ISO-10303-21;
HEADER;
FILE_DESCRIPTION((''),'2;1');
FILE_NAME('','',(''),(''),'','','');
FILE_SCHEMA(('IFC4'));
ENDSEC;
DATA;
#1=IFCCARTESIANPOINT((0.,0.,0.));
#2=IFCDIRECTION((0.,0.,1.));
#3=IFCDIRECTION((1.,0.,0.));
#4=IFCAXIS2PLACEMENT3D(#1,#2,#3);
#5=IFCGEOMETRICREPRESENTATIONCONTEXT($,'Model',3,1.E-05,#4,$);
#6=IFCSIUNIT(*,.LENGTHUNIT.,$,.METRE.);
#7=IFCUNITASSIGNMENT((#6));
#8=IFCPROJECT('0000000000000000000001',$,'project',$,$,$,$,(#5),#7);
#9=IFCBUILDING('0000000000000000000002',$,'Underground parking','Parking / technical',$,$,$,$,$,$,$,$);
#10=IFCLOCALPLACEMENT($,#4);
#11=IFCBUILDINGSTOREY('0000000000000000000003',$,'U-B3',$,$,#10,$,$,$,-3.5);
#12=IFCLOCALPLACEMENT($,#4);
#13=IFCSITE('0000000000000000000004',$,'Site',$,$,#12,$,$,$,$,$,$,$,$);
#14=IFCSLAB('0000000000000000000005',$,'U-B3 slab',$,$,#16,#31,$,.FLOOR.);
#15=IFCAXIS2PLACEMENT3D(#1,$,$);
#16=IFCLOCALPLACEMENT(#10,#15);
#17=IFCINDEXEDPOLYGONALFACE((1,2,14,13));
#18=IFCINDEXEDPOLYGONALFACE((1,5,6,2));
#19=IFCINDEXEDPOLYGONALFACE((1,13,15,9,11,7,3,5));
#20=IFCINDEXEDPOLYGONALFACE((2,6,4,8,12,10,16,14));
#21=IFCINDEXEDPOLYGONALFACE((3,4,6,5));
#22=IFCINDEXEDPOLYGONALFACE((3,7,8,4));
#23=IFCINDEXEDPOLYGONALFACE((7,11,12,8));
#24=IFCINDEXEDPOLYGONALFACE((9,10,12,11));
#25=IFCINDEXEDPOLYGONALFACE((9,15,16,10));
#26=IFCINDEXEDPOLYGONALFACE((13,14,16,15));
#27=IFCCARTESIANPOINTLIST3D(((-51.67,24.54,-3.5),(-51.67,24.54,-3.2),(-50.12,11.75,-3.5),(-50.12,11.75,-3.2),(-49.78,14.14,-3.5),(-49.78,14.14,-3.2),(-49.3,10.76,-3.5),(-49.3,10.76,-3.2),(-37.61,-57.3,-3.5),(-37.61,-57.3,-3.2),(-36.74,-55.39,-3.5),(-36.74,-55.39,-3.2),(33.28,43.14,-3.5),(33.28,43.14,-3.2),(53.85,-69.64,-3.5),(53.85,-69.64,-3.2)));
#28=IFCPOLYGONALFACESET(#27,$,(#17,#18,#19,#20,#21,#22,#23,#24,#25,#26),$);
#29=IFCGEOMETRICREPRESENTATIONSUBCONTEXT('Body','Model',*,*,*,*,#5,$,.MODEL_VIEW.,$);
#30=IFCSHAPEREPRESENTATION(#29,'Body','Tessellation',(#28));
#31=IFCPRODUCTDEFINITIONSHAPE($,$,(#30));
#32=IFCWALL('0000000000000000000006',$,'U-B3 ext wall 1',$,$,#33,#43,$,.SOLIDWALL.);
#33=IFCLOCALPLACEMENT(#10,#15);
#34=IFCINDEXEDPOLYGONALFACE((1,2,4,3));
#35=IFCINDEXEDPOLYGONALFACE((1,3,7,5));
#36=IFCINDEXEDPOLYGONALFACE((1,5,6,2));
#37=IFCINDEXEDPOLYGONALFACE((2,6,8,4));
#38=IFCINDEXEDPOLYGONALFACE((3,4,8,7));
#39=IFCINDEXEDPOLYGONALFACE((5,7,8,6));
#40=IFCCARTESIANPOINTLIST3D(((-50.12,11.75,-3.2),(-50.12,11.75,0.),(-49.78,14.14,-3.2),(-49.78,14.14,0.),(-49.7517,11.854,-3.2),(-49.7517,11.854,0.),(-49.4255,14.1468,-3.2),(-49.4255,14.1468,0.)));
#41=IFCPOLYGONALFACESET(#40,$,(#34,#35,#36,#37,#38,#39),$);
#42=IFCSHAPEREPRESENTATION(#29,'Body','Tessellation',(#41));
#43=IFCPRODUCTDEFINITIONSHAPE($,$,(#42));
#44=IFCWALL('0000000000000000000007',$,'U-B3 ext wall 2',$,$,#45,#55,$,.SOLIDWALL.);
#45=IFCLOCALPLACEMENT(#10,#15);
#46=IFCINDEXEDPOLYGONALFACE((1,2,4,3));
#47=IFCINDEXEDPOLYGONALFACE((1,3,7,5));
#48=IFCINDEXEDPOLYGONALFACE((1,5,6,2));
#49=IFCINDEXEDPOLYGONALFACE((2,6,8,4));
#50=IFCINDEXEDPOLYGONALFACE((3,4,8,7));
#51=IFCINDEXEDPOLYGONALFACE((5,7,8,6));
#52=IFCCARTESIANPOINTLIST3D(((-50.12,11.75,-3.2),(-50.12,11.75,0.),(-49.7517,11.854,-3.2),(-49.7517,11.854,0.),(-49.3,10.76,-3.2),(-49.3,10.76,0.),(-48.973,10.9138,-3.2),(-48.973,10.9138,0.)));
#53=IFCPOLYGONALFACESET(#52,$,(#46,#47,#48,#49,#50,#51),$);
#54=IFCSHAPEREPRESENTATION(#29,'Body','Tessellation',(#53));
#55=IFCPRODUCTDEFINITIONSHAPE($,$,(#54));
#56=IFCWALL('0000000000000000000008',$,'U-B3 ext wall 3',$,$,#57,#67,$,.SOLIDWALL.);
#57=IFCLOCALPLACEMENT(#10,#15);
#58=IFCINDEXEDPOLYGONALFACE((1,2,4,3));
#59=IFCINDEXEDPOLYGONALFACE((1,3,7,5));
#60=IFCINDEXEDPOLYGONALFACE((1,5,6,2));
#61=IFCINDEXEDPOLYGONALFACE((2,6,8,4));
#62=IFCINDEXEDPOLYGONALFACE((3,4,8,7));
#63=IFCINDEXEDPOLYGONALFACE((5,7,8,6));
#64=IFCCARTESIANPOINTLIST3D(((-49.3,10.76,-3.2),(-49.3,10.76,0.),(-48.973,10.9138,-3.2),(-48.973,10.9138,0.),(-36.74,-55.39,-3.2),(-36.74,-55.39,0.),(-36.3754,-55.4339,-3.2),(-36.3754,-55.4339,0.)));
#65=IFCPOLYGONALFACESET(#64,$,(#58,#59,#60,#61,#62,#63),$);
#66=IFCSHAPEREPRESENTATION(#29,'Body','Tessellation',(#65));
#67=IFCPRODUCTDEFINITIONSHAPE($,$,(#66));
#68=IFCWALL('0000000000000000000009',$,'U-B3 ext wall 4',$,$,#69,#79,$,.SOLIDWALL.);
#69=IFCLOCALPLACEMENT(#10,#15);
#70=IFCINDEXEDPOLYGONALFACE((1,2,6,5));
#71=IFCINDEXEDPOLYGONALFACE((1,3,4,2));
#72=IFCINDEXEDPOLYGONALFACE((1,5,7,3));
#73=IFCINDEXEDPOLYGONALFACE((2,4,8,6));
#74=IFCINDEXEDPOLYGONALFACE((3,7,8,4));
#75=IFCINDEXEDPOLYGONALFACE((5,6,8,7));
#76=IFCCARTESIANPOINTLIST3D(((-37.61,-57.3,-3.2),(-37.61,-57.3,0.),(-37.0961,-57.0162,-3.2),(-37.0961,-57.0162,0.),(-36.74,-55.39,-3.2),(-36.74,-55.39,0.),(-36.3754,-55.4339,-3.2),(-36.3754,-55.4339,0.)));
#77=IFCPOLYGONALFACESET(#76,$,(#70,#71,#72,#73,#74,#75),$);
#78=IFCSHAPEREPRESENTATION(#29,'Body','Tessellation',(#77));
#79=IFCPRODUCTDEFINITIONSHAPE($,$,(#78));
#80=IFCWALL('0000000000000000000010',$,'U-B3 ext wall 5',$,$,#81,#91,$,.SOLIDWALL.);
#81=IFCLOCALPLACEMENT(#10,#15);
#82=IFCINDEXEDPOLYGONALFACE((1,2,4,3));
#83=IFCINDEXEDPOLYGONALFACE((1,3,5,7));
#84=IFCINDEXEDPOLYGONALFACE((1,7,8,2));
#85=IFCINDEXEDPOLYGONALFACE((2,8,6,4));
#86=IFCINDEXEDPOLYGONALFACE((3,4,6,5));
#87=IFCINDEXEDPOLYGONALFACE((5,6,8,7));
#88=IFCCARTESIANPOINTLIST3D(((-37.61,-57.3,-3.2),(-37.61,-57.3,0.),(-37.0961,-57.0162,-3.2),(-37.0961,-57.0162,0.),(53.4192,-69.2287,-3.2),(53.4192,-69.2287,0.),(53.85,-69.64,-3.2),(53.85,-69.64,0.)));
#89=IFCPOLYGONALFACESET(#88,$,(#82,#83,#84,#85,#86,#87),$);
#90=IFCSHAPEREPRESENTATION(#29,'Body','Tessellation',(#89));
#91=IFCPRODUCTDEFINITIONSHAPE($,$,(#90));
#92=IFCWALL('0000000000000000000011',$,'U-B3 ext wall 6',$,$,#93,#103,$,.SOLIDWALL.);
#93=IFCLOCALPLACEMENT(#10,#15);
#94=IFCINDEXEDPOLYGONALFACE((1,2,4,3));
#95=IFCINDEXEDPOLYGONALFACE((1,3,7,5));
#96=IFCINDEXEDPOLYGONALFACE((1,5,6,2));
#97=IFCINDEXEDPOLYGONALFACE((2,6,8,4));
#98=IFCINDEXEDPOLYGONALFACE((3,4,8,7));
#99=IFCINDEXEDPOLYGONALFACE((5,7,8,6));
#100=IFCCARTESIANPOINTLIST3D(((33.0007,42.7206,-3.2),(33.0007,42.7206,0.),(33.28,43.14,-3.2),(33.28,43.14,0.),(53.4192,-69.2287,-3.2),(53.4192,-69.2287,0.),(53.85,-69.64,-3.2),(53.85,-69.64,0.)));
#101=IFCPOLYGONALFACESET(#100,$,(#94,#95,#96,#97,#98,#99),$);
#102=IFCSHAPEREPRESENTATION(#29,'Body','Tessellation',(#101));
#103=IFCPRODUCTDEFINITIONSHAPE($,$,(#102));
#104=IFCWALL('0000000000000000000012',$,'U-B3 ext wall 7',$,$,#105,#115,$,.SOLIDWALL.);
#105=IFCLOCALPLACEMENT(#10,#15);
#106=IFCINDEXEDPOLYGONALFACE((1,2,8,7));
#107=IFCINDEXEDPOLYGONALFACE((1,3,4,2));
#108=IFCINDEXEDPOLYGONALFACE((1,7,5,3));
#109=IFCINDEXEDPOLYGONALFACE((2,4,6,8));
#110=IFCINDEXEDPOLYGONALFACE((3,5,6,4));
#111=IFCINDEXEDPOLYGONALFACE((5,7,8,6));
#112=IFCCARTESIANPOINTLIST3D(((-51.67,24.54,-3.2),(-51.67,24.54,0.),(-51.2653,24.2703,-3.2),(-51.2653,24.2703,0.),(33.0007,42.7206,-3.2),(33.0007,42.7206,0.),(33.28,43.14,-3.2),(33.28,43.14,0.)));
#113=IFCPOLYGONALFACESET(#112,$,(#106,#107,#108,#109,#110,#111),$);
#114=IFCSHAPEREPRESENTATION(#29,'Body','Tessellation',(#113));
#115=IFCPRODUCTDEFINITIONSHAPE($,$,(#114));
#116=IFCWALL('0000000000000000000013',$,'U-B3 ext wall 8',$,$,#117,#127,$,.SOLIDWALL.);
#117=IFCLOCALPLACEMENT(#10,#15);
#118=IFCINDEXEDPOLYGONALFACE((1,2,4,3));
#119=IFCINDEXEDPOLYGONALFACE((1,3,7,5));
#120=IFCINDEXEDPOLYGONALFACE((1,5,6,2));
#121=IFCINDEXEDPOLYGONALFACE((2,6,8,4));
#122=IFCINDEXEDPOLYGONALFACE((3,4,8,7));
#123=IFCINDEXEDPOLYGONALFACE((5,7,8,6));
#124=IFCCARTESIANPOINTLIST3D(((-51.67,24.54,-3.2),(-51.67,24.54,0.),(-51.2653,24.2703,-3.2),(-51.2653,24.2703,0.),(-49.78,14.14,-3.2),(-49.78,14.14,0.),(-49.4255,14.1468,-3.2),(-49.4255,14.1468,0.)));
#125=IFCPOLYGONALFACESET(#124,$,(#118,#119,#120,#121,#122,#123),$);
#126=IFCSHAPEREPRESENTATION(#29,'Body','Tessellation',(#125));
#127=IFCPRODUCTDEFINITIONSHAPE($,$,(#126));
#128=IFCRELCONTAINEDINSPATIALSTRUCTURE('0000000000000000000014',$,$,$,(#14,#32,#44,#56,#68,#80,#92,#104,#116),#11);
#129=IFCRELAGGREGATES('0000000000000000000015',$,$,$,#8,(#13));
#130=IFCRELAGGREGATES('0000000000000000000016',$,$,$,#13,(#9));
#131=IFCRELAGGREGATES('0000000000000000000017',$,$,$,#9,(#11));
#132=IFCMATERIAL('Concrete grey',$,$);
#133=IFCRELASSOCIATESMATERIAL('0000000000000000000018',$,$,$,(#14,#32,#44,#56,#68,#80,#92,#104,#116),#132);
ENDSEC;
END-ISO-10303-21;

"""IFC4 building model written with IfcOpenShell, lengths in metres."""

from ifc_helpers import new_model, si_unit, frame, origin_with_axes, place, context, subcontext, project, spatial, polyline, outline, extrude, material, element, save


model = new_model("IFC4")

# Units and contexts
model_context = context("Model", 3, precision=1e-05, world=origin_with_axes())
body_context = subcontext(model_context, "Body", "Model", "MODEL_VIEW")
ifc_project = project(units=[si_unit("LENGTHUNIT", "METRE")], contexts=[model_context])

# Site, building, storey
site_placement = place(None, origin_with_axes())
site = spatial("IfcSite", under=ifc_project, at=site_placement, Name="Site")
building = spatial("IfcBuilding", under=site, Name="Underground parking", Description="Parking / technical")
storey_placement = place(None, origin_with_axes())
storey = spatial("IfcBuildingStorey", under=building, at=storey_placement, Name="U-B3", Elevation=-3.5)

# Slab
ifc_material = material(Name="Concrete grey")
slab_placement = place(storey_placement, origin_with_axes())
element("IfcSlab", 1, at=slab_placement, inside=storey, material=ifc_material, Name="U-B3 slab", PredefinedType="FLOOR", context=body_context, shape_type="SweptSolid", body=[
    extrude(outline(polyline([(-49.78, 14.14), (-50.12, 11.75), (-49.3, 10.76), (-36.74, -55.39), (-37.61, -57.3), (53.85, -69.64), (33.28, 43.14), (-51.67, 24.54), (-49.78, 14.14)])), frame((0.0, 0.0, -3.5), z_axis=(0.0, 0.0, 1.0), x_axis=(1.0, 0.0, 0.0)), (0.0, 0.0, 1.0), 0.3),
])

# Walls
wall_1_placement = place(storey_placement, origin_with_axes())
element("IfcWall", 2, at=wall_1_placement, inside=storey, material=ifc_material, Name="U-B3 ext wall 1", PredefinedType="SOLIDWALL", context=body_context, shape_type="SweptSolid", body=[
    extrude(outline(polyline([(-49.78, 14.14), (-50.12, 11.75), (-49.7517, 11.854), (-49.4255, 14.1468), (-49.78, 14.14)])), frame((0.0, 0.0, -3.2), z_axis=(0.0, 0.0, 1.0), x_axis=(1.0, 0.0, 0.0)), (0.0, 0.0, 1.0), 3.2),
])
wall_2_placement = place(storey_placement, origin_with_axes())
element("IfcWall", 3, at=wall_2_placement, inside=storey, material=ifc_material, Name="U-B3 ext wall 2", PredefinedType="SOLIDWALL", context=body_context, shape_type="SweptSolid", body=[
    extrude(outline(polyline([(-50.12, 11.75), (-49.3, 10.76), (-48.973, 10.9138), (-49.7517, 11.854), (-50.12, 11.75)])), frame((0.0, 0.0, -3.2), z_axis=(0.0, 0.0, 1.0), x_axis=(1.0, 0.0, 0.0)), (0.0, 0.0, 1.0), 3.2),
])
wall_3_placement = place(storey_placement, origin_with_axes())
element("IfcWall", 4, at=wall_3_placement, inside=storey, material=ifc_material, Name="U-B3 ext wall 3", PredefinedType="SOLIDWALL", context=body_context, shape_type="SweptSolid", body=[
    extrude(outline(polyline([(-49.3, 10.76), (-36.74, -55.39), (-36.3754, -55.4339), (-48.973, 10.9138), (-49.3, 10.76)])), frame((0.0, 0.0, -3.2), z_axis=(0.0, 0.0, 1.0), x_axis=(1.0, 0.0, 0.0)), (0.0, 0.0, 1.0), 3.2),
])
wall_4_placement = place(storey_placement, origin_with_axes())
element("IfcWall", 5, at=wall_4_placement, inside=storey, material=ifc_material, Name="U-B3 ext wall 4", PredefinedType="SOLIDWALL", context=body_context, shape_type="SweptSolid", body=[
    extrude(outline(polyline([(-36.74, -55.39), (-37.61, -57.3), (-37.0961, -57.0162), (-36.3754, -55.4339), (-36.74, -55.39)])), frame((0.0, 0.0, -3.2), z_axis=(0.0, 0.0, 1.0), x_axis=(1.0, 0.0, 0.0)), (0.0, 0.0, 1.0), 3.2),
])
wall_5_placement = place(storey_placement, origin_with_axes())
element("IfcWall", 6, at=wall_5_placement, inside=storey, material=ifc_material, Name="U-B3 ext wall 5", PredefinedType="SOLIDWALL", context=body_context, shape_type="SweptSolid", body=[
    extrude(outline(polyline([(-37.61, -57.3), (53.85, -69.64), (53.4192, -69.2287), (-37.0961, -57.0162), (-37.61, -57.3)])), frame((0.0, 0.0, -3.2), z_axis=(0.0, 0.0, 1.0), x_axis=(1.0, 0.0, 0.0)), (0.0, 0.0, 1.0), 3.2),
])
wall_6_placement = place(storey_placement, origin_with_axes())
element("IfcWall", 7, at=wall_6_placement, inside=storey, material=ifc_material, Name="U-B3 ext wall 6", PredefinedType="SOLIDWALL", context=body_context, shape_type="SweptSolid", body=[
    extrude(outline(polyline([(53.85, -69.64), (33.28, 43.14), (33.0007, 42.7206), (53.4192, -69.2287), (53.85, -69.64)])), frame((0.0, 0.0, -3.2), z_axis=(0.0, 0.0, 1.0), x_axis=(1.0, 0.0, 0.0)), (0.0, 0.0, 1.0), 3.2),
])
wall_7_placement = place(storey_placement, origin_with_axes())
element("IfcWall", 8, at=wall_7_placement, inside=storey, material=ifc_material, Name="U-B3 ext wall 7", PredefinedType="SOLIDWALL", context=body_context, shape_type="SweptSolid", body=[
    extrude(outline(polyline([(33.28, 43.14), (-51.67, 24.54), (-51.2653, 24.2703), (33.0007, 42.7206), (33.28, 43.14)])), frame((0.0, 0.0, -3.2), z_axis=(0.0, 0.0, 1.0), x_axis=(1.0, 0.0, 0.0)), (0.0, 0.0, 1.0), 3.2),
])
wall_8_placement = place(storey_placement, origin_with_axes())
element("IfcWall", 9, at=wall_8_placement, inside=storey, material=ifc_material, Name="U-B3 ext wall 8", PredefinedType="SOLIDWALL", context=body_context, shape_type="SweptSolid", body=[
    extrude(outline(polyline([(-51.67, 24.54), (-49.78, 14.14), (-49.4255, 14.1468), (-51.2653, 24.2703), (-51.67, 24.54)])), frame((0.0, 0.0, -3.2), z_axis=(0.0, 0.0, 1.0), x_axis=(1.0, 0.0, 0.0)), (0.0, 0.0, 1.0), 3.2),
])

save(model, "model.ifc")
